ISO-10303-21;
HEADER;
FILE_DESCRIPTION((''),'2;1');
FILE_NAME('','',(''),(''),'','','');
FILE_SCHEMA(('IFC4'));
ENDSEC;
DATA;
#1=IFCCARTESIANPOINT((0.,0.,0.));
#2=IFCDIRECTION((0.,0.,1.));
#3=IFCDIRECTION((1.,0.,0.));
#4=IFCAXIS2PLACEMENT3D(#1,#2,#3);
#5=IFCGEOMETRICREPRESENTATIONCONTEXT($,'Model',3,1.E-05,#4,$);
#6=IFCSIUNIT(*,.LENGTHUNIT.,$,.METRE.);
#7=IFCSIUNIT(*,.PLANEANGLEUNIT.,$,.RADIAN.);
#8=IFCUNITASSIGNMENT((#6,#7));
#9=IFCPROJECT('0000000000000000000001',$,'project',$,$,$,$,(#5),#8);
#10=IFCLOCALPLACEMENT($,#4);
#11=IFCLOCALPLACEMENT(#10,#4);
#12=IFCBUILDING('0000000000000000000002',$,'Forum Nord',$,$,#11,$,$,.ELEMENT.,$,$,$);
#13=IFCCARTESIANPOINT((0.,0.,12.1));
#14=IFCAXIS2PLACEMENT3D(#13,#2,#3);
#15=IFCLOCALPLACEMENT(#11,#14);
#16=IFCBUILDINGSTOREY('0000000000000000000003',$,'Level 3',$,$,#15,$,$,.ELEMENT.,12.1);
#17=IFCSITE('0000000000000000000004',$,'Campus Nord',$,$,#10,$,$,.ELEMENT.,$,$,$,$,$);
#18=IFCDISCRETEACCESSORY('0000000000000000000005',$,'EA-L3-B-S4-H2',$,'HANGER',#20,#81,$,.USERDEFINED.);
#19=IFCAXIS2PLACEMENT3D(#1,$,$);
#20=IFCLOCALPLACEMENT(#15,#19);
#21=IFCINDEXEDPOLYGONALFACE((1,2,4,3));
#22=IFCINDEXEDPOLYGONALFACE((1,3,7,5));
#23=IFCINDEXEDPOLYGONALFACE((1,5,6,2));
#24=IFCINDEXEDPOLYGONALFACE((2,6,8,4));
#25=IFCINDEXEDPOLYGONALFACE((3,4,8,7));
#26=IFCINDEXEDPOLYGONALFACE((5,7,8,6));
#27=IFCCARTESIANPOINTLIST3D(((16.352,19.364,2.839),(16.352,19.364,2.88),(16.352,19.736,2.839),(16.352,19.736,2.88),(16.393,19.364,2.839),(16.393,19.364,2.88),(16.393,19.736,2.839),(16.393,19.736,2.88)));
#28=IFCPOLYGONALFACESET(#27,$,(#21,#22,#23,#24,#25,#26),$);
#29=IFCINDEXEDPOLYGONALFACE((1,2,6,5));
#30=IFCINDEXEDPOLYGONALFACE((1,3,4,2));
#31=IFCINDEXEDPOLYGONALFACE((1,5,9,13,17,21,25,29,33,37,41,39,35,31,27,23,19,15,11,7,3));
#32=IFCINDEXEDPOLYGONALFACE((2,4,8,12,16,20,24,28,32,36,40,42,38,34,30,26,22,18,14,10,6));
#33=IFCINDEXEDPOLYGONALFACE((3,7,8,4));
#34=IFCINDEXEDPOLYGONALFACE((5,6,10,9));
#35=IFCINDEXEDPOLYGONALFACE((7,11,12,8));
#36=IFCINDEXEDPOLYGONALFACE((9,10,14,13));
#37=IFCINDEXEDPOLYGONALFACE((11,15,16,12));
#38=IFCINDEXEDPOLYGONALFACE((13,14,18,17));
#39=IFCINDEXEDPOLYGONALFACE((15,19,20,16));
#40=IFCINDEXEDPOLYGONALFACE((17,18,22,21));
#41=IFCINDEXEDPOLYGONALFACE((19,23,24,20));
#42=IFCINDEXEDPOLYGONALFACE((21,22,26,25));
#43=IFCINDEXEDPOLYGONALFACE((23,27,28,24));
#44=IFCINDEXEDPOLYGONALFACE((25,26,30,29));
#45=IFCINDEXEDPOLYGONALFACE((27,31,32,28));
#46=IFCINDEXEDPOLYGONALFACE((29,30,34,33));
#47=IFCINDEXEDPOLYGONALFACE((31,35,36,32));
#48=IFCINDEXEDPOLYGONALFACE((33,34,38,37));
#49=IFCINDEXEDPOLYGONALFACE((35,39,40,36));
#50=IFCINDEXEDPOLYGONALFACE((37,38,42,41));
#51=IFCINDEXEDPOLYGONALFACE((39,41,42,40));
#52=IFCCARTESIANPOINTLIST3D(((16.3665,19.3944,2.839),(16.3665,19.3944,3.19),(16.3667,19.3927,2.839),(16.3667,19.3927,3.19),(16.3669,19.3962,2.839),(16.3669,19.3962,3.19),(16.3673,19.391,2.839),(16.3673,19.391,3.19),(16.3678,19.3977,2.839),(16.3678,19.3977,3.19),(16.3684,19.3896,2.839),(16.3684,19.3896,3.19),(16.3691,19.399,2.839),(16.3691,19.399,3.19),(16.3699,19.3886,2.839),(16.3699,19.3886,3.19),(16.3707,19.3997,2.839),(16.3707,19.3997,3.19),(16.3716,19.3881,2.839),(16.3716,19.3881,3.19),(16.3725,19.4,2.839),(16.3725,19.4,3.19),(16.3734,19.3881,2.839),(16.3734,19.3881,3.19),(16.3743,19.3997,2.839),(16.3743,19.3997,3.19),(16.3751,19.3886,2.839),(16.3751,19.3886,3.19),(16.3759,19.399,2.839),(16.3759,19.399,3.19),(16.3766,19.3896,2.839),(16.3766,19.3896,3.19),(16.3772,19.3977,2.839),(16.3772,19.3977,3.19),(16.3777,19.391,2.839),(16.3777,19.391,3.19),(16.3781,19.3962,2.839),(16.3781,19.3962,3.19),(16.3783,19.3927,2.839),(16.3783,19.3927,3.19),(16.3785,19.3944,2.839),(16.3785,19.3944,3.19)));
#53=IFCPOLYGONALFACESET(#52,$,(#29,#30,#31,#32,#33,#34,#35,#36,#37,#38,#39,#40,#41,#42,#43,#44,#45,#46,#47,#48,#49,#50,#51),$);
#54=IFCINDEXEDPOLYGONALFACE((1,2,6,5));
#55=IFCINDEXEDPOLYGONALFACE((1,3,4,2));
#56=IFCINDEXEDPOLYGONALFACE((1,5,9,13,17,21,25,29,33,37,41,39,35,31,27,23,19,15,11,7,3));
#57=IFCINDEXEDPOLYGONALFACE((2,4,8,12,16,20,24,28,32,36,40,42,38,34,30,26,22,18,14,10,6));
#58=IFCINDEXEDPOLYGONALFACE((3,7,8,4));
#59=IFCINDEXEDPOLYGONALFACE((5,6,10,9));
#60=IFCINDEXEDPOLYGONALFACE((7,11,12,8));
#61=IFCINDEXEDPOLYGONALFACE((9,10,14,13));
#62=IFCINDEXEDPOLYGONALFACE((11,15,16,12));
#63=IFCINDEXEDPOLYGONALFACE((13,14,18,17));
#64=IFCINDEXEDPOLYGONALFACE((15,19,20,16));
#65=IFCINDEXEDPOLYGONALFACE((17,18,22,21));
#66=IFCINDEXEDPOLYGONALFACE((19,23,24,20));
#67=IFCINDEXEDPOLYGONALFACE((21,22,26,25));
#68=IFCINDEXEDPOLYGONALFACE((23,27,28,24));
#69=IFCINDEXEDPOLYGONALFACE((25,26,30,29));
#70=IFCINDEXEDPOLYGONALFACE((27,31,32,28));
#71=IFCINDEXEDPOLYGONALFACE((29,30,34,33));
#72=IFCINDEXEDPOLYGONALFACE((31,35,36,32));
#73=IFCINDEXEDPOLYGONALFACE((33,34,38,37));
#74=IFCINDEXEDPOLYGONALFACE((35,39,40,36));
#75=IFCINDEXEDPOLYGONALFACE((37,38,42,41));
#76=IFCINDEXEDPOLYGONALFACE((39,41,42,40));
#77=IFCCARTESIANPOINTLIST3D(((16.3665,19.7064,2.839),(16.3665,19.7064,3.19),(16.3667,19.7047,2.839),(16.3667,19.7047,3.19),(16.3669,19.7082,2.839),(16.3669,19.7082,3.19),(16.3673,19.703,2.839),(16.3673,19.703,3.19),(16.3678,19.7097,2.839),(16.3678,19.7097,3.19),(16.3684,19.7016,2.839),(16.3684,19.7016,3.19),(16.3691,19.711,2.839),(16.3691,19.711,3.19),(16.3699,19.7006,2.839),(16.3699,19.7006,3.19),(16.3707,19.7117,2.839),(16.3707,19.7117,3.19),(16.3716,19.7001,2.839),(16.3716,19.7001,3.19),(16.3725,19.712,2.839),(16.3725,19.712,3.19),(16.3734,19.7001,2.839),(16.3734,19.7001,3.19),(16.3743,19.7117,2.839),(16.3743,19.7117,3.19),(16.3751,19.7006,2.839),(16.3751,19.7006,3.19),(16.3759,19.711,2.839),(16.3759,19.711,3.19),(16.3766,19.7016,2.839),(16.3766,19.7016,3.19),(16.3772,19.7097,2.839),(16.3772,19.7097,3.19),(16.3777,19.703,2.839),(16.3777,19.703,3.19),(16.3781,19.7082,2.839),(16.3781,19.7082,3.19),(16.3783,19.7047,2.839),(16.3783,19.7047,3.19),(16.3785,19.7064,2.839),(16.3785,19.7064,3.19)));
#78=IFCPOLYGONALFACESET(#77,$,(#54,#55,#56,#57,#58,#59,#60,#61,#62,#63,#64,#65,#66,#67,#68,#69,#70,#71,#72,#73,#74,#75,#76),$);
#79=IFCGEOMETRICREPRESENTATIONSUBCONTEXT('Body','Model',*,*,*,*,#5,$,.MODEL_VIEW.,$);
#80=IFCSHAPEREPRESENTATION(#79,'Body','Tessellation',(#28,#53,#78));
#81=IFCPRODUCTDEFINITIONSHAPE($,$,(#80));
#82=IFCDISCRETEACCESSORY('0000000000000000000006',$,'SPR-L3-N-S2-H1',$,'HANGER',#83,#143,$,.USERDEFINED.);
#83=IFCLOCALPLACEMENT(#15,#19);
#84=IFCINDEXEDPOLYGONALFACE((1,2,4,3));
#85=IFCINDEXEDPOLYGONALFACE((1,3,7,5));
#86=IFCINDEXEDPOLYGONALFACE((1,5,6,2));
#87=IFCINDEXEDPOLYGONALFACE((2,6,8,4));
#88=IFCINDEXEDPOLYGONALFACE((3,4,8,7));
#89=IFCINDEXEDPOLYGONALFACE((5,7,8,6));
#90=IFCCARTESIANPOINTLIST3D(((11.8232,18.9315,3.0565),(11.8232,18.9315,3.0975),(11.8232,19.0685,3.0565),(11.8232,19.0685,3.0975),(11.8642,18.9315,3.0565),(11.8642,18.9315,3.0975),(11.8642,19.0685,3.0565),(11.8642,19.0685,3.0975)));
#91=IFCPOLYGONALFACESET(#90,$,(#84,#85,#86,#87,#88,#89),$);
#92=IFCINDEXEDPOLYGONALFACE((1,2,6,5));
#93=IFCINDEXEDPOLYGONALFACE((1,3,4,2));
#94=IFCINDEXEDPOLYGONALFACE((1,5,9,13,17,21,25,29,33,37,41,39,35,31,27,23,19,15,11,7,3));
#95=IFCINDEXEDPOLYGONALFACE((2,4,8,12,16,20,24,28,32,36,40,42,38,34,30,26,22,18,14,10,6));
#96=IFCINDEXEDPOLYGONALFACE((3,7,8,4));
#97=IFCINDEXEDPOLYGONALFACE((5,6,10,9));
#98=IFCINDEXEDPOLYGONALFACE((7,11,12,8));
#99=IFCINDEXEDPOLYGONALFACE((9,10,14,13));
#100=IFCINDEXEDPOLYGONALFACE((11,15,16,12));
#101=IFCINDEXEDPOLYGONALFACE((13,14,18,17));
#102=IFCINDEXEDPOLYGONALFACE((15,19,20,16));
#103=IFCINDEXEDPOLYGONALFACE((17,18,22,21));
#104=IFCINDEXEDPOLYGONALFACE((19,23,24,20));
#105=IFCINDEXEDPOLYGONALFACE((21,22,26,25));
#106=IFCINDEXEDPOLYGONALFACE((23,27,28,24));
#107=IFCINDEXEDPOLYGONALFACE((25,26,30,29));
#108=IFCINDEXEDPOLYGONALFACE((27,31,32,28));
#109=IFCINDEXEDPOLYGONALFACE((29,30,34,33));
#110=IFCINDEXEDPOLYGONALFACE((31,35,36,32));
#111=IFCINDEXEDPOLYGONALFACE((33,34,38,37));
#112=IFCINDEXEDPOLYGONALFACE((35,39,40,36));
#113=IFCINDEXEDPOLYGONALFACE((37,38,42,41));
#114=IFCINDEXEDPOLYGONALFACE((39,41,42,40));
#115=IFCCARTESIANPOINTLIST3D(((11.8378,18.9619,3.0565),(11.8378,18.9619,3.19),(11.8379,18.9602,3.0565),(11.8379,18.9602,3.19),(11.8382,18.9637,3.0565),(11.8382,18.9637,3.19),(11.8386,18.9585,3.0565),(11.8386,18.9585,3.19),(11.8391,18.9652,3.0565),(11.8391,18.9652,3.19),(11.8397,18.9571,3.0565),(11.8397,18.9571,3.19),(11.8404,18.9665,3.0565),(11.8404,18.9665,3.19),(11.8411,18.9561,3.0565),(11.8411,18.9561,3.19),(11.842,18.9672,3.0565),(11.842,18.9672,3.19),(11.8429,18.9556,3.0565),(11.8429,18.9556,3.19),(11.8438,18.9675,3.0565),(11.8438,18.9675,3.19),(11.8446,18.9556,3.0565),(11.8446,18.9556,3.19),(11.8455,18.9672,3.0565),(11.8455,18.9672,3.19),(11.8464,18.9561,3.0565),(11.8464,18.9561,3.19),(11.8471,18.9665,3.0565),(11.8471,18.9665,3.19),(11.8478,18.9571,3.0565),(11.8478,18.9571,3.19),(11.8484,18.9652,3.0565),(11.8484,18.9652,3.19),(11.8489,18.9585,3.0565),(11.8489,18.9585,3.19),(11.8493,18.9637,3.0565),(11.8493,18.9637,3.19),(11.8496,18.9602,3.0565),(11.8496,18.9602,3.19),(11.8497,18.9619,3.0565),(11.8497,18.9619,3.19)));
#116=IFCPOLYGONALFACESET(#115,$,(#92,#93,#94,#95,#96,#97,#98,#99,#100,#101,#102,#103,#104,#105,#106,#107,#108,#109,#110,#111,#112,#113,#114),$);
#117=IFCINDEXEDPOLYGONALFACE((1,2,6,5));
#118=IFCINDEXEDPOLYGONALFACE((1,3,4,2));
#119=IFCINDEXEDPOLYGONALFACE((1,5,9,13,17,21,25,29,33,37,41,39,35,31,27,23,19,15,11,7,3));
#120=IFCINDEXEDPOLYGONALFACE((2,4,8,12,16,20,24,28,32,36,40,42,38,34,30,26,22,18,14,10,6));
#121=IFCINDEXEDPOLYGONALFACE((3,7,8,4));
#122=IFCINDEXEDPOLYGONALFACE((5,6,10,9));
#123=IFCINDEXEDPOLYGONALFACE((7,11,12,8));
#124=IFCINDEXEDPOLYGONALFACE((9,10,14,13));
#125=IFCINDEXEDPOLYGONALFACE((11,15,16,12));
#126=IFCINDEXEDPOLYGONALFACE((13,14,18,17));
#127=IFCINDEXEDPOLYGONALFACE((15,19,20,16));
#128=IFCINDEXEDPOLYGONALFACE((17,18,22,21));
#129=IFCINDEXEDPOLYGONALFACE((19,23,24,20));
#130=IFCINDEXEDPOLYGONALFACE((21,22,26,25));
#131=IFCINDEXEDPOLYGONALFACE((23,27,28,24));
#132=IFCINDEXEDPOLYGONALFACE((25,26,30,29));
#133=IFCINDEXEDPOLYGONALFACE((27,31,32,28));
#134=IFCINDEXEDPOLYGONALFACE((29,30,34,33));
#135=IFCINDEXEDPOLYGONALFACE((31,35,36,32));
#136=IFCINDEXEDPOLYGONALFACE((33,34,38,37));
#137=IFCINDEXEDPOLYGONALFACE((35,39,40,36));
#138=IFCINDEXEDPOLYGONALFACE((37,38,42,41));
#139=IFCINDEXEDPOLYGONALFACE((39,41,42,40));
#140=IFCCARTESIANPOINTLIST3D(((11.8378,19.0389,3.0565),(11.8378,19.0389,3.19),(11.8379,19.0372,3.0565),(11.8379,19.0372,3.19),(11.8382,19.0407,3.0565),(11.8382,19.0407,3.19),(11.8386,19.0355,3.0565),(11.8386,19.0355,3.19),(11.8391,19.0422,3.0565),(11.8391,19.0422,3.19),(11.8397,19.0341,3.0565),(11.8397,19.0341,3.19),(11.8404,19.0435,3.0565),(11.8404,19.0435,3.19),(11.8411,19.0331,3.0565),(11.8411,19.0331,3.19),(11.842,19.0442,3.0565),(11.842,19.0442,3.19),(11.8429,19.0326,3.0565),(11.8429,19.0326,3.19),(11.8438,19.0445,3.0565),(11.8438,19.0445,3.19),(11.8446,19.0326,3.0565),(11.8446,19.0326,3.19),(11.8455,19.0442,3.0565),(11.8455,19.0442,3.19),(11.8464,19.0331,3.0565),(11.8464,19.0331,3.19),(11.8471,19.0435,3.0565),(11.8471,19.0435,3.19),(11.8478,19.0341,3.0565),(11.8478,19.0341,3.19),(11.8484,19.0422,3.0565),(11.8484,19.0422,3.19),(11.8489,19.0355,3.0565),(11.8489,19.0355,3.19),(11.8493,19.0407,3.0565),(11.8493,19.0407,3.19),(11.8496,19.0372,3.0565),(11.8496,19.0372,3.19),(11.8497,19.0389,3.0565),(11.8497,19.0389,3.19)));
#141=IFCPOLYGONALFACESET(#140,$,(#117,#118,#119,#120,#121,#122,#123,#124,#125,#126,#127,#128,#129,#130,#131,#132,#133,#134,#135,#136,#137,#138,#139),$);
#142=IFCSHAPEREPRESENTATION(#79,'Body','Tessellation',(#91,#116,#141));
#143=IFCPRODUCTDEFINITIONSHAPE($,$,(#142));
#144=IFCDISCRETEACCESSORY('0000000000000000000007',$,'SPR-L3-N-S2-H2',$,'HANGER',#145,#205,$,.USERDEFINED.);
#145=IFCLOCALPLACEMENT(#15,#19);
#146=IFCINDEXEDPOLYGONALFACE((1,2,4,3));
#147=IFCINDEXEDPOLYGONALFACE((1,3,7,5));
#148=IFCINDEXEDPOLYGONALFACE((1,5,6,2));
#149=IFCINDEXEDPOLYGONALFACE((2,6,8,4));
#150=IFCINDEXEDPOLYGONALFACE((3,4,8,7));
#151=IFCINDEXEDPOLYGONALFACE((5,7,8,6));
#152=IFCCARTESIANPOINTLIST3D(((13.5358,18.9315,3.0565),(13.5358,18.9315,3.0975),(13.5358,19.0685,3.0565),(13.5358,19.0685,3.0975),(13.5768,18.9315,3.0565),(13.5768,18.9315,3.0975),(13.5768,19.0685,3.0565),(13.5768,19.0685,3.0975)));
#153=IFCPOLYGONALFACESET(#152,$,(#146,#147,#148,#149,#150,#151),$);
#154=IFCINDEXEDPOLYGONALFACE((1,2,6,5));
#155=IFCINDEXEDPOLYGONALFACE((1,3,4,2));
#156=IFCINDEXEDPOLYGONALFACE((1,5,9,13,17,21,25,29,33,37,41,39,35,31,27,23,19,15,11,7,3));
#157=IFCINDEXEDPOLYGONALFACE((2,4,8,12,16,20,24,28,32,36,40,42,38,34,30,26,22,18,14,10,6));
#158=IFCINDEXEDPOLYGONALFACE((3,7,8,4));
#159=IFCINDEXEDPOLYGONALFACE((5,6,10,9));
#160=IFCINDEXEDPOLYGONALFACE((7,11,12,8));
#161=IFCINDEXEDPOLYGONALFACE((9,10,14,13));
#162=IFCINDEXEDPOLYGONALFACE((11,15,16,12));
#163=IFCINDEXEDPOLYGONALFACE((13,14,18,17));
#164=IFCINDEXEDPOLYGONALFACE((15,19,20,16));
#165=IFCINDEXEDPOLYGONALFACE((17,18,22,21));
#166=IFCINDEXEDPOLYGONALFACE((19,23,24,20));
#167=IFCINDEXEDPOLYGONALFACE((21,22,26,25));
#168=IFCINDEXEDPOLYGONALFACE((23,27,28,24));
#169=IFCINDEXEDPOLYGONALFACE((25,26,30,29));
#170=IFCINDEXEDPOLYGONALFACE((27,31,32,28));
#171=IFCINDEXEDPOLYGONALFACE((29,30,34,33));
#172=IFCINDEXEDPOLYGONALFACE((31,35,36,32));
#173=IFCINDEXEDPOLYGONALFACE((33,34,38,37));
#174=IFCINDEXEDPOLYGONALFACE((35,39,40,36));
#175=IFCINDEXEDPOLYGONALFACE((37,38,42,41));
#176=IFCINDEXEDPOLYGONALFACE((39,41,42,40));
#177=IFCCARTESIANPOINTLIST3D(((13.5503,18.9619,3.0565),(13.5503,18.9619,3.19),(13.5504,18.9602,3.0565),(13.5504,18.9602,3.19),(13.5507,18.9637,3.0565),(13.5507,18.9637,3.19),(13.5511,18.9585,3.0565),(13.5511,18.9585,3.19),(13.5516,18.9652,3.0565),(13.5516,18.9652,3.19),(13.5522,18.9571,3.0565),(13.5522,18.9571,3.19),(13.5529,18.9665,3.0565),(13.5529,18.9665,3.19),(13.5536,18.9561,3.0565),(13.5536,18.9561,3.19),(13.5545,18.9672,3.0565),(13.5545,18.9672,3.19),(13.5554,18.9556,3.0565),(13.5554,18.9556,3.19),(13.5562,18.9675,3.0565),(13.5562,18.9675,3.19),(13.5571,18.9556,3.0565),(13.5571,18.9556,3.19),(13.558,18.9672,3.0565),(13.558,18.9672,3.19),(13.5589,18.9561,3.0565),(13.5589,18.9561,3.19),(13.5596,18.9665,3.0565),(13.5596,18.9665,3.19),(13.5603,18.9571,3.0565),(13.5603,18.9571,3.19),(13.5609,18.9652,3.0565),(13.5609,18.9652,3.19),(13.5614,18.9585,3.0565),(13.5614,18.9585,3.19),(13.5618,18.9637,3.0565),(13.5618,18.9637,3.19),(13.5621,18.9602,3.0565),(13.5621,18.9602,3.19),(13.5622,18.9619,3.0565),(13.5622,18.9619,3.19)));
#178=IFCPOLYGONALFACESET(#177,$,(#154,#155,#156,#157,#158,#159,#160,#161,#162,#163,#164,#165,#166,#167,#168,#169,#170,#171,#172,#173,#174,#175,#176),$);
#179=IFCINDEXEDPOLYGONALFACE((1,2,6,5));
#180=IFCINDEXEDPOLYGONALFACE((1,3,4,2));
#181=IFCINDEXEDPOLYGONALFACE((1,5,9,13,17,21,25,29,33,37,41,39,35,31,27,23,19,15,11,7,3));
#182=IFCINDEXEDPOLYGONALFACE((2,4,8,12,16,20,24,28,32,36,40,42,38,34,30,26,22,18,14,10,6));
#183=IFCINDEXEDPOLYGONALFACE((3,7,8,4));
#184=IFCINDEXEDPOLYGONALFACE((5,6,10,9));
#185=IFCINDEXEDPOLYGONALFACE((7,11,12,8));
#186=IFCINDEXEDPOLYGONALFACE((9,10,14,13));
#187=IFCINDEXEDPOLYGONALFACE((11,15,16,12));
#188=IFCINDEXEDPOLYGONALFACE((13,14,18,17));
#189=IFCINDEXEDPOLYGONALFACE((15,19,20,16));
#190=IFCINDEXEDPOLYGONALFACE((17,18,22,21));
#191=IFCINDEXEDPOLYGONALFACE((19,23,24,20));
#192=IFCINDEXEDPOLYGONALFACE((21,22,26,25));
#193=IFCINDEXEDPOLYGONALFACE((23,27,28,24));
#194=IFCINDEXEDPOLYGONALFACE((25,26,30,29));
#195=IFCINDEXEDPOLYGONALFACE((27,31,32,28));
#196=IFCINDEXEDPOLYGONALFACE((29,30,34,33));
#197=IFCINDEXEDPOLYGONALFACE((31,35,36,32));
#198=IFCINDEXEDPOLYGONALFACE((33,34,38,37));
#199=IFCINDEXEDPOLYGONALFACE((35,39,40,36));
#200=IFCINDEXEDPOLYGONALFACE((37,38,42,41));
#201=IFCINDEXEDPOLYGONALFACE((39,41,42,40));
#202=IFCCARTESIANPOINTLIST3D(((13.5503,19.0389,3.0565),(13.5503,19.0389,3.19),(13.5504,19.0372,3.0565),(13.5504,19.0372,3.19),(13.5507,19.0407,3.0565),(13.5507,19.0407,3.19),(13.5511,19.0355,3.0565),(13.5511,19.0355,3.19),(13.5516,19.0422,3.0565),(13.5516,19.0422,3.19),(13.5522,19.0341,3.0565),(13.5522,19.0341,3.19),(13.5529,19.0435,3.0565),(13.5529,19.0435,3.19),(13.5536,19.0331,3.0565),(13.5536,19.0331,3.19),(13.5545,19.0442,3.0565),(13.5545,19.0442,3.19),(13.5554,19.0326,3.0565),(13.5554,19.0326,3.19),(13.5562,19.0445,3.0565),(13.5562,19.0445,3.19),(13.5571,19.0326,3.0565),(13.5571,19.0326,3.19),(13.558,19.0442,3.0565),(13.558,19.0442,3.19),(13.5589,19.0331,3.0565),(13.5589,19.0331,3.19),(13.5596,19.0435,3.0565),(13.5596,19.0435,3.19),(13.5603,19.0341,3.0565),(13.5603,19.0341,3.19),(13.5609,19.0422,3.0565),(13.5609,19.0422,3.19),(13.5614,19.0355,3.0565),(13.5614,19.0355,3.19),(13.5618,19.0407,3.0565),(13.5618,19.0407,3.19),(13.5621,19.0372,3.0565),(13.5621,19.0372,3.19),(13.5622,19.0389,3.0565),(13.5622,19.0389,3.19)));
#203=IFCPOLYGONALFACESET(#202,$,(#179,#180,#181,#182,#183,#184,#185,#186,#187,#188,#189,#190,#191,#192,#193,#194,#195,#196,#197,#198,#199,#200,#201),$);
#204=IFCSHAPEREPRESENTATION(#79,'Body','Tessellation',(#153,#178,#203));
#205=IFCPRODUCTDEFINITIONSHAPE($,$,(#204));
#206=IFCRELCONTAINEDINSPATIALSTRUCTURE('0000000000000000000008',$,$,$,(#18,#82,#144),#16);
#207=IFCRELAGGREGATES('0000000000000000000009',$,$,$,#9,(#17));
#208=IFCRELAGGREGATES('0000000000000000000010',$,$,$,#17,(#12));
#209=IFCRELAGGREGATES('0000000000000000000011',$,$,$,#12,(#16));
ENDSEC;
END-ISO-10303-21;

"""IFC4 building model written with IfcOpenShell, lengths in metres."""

from ifc_helpers import new_model, si_unit, frame, frame_2d, origin_with_axes, origin_2d_with_axis, place, context, subcontext, project, spatial, rectangle, circle, extrude, element, save


model = new_model("IFC4")

# Units and contexts
model_context = context("Model", 3, precision=1e-05, world=origin_with_axes())
body_context = subcontext(model_context, "Body", "Model", "MODEL_VIEW")
ifc_project = project(units=[si_unit("LENGTHUNIT", "METRE"), si_unit("PLANEANGLEUNIT", "RADIAN")], contexts=[model_context])

# Site, building, storey
site_placement = place(None, origin_with_axes())
site = spatial("IfcSite", under=ifc_project, at=site_placement, Name="Campus Nord", CompositionType="ELEMENT")
building_placement = place(site_placement, origin_with_axes())
building = spatial("IfcBuilding", under=site, at=building_placement, Name="Forum Nord", CompositionType="ELEMENT")
storey_placement = place(building_placement, frame((0.0, 0.0, 12.1), z_axis=(0.0, 0.0, 1.0), x_axis=(1.0, 0.0, 0.0)))
storey = spatial("IfcBuildingStorey", under=building, at=storey_placement, Name="Level 3", CompositionType="ELEMENT", Elevation=12.1)

# Discrete accessories
for number, where, z_axis, x_axis, name in (
    (1, (16.3725, 19.55, 2.88), (0.0, 0.0, 1.0), (0.0, 1.0, 0.0), "EA-L3-B-S4-H2"),
):
    element("IfcDiscreteAccessory", number, at=place(storey_placement, frame(where, z_axis=z_axis, x_axis=x_axis)), inside=storey, Name=name, ObjectType="HANGER", PredefinedType="USERDEFINED", context=body_context, shape_type="SweptSolid", body=[
        extrude(rectangle(XDim=0.372, YDim=0.041, at=origin_2d_with_axis()), frame((0.0, 0.0, -0.041), z_axis=(0.0, 0.0, 1.0), x_axis=(1.0, 0.0, 0.0)), (0.0, 0.0, 1.0), 0.041),
        extrude(circle(Radius=0.006, at=frame_2d((-0.156, 0.0), x_axis=(1.0, 0.0))), frame((0.0, 0.0, -0.041), z_axis=(0.0, 0.0, 1.0), x_axis=(1.0, 0.0, 0.0)), (0.0, 0.0, 1.0), 0.351),
        extrude(circle(Radius=0.006, at=frame_2d((0.156, 0.0), x_axis=(1.0, 0.0))), frame((0.0, 0.0, -0.041), z_axis=(0.0, 0.0, 1.0), x_axis=(1.0, 0.0, 0.0)), (0.0, 0.0, 1.0), 0.351),
    ])
for number, where, z_axis, x_axis, name in (
    (2, (11.8438, 19.0, 3.0975), (0.0, 0.0, 1.0), (0.0, 1.0, 0.0), "SPR-L3-N-S2-H1"),
    (3, (13.5563, 19.0, 3.0975), (0.0, 0.0, 1.0), (0.0, 1.0, 0.0), "SPR-L3-N-S2-H2"),
):
    element("IfcDiscreteAccessory", number, at=place(storey_placement, frame(where, z_axis=z_axis, x_axis=x_axis)), inside=storey, Name=name, ObjectType="HANGER", PredefinedType="USERDEFINED", context=body_context, shape_type="SweptSolid", body=[
        extrude(rectangle(XDim=0.137, YDim=0.041, at=origin_2d_with_axis()), frame((0.0, 0.0, -0.041), z_axis=(0.0, 0.0, 1.0), x_axis=(1.0, 0.0, 0.0)), (0.0, 0.0, 1.0), 0.041),
        extrude(circle(Radius=0.006, at=frame_2d((-0.0385, 0.0), x_axis=(1.0, 0.0))), frame((0.0, 0.0, -0.041), z_axis=(0.0, 0.0, 1.0), x_axis=(1.0, 0.0, 0.0)), (0.0, 0.0, 1.0), 0.1335),
        extrude(circle(Radius=0.006, at=frame_2d((0.0385, 0.0), x_axis=(1.0, 0.0))), frame((0.0, 0.0, -0.041), z_axis=(0.0, 0.0, 1.0), x_axis=(1.0, 0.0, 0.0)), (0.0, 0.0, 1.0), 0.1335),
    ])

save(model, "model.ifc")
